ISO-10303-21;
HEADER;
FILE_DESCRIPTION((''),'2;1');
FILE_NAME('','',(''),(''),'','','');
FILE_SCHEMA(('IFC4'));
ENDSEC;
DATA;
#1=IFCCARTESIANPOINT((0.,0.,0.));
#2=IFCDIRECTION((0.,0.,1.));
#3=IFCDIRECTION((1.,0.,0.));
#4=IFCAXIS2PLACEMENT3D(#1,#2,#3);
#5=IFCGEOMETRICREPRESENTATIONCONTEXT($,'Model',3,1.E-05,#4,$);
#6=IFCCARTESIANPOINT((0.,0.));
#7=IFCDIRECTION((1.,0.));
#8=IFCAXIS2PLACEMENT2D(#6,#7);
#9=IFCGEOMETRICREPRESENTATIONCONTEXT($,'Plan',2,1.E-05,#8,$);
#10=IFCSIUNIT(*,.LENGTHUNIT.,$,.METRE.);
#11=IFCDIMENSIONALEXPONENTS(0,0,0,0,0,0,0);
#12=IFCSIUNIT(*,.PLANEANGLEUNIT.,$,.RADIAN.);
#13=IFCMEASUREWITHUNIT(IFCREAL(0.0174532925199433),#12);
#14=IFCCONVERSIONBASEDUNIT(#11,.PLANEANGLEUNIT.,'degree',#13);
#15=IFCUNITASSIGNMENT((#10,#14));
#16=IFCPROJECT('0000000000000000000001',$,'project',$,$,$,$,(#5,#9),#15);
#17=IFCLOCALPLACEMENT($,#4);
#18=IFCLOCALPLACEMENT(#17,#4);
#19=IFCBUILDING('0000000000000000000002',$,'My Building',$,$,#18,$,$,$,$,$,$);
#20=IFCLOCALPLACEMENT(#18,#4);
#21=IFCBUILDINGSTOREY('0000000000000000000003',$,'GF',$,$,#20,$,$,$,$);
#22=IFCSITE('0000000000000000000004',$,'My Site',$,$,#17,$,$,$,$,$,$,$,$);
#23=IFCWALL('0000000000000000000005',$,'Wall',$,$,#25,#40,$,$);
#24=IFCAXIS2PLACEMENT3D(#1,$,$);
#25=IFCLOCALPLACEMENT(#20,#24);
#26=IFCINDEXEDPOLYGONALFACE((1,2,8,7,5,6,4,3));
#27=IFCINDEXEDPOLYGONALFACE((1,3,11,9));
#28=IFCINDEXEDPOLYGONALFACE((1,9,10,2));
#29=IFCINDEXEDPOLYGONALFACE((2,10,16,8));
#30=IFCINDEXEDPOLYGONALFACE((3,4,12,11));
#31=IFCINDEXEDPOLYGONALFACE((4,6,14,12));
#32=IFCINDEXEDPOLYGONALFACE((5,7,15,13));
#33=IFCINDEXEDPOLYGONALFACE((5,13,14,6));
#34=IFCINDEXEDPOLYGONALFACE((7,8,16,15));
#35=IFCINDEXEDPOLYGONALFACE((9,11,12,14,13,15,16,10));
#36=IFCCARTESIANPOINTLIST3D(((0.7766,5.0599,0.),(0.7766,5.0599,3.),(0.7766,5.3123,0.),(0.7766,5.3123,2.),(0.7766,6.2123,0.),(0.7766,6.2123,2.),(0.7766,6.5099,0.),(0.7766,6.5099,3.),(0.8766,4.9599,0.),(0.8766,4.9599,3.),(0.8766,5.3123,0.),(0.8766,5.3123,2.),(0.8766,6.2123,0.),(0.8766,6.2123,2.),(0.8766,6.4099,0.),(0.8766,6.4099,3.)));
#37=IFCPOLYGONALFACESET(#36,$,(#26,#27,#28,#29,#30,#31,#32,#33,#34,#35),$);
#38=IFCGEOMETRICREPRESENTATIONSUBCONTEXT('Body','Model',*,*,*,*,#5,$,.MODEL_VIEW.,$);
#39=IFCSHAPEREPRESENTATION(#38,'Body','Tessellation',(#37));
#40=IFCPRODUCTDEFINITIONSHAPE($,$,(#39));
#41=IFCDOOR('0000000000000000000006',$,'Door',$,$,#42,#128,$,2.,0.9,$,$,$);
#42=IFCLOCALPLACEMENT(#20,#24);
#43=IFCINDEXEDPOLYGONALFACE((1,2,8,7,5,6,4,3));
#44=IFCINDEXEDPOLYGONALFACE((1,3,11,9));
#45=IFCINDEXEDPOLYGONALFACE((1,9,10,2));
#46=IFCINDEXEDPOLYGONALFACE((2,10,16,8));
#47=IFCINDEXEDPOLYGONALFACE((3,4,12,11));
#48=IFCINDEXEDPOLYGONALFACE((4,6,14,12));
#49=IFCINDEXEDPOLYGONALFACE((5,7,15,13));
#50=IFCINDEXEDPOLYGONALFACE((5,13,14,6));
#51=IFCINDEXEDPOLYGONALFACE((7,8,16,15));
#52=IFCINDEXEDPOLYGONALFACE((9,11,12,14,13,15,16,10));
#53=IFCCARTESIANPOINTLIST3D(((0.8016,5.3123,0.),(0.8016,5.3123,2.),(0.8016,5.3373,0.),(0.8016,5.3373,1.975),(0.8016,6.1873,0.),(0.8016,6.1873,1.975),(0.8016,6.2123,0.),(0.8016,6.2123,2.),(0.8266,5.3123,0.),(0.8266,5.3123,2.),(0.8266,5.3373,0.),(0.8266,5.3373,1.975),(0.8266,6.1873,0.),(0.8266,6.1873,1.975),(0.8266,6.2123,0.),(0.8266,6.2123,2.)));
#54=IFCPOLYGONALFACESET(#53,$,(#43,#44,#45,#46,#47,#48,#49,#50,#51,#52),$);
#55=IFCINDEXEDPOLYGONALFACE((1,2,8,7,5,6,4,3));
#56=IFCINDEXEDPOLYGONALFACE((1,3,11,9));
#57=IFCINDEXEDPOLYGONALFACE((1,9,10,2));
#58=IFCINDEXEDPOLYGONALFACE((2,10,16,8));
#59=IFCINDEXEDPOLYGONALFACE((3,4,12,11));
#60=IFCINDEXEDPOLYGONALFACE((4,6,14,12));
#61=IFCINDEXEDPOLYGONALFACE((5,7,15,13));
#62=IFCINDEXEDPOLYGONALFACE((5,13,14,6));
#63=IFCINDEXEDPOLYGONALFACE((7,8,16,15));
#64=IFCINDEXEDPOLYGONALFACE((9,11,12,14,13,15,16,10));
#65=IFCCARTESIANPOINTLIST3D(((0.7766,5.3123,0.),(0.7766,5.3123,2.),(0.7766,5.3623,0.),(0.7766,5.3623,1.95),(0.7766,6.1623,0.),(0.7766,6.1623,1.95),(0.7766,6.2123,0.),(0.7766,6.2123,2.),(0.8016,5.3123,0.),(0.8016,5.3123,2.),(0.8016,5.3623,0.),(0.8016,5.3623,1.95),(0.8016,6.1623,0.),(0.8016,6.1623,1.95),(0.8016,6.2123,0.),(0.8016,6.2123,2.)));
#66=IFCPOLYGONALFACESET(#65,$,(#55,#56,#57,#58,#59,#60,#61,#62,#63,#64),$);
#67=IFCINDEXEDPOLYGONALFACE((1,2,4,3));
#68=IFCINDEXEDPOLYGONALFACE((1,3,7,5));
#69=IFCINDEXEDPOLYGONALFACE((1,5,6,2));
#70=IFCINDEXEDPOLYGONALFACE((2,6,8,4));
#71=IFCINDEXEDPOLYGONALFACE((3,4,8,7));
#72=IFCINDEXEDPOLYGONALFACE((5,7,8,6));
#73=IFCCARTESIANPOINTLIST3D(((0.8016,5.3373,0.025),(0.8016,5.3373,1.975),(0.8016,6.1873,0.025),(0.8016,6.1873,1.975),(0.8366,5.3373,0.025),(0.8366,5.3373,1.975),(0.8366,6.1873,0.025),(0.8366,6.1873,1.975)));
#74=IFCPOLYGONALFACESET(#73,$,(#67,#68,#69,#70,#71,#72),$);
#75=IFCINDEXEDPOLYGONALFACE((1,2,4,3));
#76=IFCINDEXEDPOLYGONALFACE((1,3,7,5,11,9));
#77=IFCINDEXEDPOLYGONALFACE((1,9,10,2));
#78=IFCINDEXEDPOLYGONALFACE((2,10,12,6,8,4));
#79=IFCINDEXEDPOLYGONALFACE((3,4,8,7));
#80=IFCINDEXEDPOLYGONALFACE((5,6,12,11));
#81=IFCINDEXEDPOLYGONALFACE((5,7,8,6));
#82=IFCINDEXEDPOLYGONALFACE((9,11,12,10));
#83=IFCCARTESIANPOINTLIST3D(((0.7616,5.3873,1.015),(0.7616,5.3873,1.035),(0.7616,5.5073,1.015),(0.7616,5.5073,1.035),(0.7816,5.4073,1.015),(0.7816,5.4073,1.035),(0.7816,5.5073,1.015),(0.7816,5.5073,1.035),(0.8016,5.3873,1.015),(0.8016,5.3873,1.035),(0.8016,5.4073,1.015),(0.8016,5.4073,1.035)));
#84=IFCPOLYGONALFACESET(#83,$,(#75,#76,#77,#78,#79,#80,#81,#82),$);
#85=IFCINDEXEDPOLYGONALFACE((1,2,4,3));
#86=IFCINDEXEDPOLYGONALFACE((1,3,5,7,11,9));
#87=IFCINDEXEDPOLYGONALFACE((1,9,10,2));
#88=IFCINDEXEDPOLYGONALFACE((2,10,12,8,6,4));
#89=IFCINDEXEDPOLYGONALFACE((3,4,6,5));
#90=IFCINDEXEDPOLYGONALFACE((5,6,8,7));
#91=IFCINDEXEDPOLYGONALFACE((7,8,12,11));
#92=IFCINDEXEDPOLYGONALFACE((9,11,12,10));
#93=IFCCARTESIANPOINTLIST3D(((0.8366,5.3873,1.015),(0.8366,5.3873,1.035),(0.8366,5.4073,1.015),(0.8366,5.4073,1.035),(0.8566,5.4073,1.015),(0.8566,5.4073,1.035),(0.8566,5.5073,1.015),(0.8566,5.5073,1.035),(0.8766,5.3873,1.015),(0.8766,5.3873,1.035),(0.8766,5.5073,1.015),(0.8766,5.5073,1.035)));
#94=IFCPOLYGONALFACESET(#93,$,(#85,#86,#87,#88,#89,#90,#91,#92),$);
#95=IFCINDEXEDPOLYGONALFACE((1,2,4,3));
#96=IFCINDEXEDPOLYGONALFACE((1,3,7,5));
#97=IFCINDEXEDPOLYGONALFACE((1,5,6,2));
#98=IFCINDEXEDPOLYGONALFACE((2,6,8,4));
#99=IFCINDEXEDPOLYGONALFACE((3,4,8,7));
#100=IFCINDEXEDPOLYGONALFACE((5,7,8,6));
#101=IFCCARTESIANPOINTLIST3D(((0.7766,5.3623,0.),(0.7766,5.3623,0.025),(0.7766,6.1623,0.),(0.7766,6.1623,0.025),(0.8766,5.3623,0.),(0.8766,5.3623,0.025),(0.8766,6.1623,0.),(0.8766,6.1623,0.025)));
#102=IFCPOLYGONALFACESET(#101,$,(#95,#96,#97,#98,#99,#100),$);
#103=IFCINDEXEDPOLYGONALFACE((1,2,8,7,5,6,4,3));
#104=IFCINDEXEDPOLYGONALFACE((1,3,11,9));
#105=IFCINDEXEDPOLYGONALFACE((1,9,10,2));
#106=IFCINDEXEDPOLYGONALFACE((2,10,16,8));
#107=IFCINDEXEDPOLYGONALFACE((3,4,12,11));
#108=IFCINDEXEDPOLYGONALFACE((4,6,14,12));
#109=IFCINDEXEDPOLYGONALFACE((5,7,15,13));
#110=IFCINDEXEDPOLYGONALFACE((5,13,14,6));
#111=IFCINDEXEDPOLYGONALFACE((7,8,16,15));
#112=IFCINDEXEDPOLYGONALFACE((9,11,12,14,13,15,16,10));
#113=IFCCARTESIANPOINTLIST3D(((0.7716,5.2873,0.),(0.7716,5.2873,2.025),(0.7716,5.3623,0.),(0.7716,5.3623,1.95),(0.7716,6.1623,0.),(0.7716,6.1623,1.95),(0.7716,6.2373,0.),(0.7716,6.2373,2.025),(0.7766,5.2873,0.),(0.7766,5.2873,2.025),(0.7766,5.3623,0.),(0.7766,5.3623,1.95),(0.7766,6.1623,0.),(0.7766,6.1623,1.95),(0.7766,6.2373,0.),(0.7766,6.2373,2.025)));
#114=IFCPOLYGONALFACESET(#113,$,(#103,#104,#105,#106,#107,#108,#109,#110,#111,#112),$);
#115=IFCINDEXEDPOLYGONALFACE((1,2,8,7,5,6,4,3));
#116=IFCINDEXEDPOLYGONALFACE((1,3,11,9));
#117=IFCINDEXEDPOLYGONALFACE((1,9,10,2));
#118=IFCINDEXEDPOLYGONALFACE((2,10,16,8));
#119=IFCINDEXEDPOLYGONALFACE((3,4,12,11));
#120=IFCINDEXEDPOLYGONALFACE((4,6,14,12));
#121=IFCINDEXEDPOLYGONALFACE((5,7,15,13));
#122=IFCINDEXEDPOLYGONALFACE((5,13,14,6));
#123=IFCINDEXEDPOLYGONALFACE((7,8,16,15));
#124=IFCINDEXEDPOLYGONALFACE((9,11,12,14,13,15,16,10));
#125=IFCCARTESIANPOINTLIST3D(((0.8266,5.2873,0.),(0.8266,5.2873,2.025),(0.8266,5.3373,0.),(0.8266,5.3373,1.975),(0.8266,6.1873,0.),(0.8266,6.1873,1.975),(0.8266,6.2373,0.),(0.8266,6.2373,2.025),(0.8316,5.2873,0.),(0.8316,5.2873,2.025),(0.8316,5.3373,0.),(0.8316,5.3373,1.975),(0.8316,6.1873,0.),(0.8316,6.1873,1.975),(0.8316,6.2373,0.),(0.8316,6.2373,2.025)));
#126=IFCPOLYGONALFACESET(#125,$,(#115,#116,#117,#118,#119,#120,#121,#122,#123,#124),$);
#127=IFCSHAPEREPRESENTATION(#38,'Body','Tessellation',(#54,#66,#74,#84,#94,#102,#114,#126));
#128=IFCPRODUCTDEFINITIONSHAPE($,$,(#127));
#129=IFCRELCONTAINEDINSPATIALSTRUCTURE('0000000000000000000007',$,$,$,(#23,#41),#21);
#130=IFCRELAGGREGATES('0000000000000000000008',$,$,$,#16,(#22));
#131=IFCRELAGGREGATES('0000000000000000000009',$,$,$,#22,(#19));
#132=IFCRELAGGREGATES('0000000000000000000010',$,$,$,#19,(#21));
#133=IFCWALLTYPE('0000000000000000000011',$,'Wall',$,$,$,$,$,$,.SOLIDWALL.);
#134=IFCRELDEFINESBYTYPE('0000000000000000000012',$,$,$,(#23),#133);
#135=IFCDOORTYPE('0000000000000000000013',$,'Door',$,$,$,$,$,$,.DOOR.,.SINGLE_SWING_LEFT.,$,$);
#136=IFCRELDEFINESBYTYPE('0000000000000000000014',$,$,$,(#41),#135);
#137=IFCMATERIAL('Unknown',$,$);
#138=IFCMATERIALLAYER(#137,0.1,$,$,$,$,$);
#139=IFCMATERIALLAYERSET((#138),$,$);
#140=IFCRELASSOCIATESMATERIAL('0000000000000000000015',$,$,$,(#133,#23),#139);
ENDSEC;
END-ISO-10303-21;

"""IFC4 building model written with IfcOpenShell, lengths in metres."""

from ifc_helpers import new_model, entity, si_unit, converted_unit, frame, origin_with_axes, origin_2d_with_axis, place, context, subcontext, project, spatial, line, indexed_curve, outline, extrude, shape, source, transform, mapped, material, layer, layer_set, layer_usage, type_object, type_shapes, element, fill, save


model = new_model("IFC4")

# Units and contexts
model_context = context("Model", 3, precision=1e-05, world=origin_with_axes())
plan_context = context("Plan", 2, precision=1e-05, world=origin_2d_with_axis())
body_context_1 = subcontext(model_context, "Body", "Model", "MODEL_VIEW")
body_context_2 = subcontext(plan_context, "Body", "Plan", "PLAN_VIEW")
ifc_project = project(units=[si_unit("LENGTHUNIT", "METRE"), converted_unit("PLANEANGLEUNIT", "degree", entity("IfcReal", 0.0174532925199433), si_unit("PLANEANGLEUNIT", "RADIAN"), dimensions=[0, 0, 0, 0, 0, 0, 0])], contexts=[model_context, plan_context])

# Site, building, storey
site_placement = place(None, origin_with_axes())
site = spatial("IfcSite", under=ifc_project, at=site_placement, Name="My Site")
building_placement = place(site_placement, origin_with_axes())
building = spatial("IfcBuilding", under=site, at=building_placement, Name="My Building")
storey_placement = place(building_placement, origin_with_axes())
storey = spatial("IfcBuildingStorey", under=building, at=storey_placement, Name="GF")

# Shared definitions
ifc_material_1 = material(Name="Unknown")

# Shared definitions
ifc_layer_1 = layer(ifc_material_1, 0.1)
ifc_layer_set_1 = layer_set([ifc_layer_1])
wall_type = type_object("IfcWallType", Name="Wall", PredefinedType="SOLIDWALL", material=ifc_layer_set_1)

# Wall, opening, door
ifc_layer_usage_1 = layer_usage(ifc_layer_set_1, "AXIS2", "POSITIVE", 0.0)
wall_1_placement = place(storey_placement, frame((0.7766, 6.5099, 0.0), z_axis=(0.0, 0.0, 1.0), x_axis=(0.0, -1.0, 0.0)))
wall_1 = element("IfcWall", 1, at=wall_1_placement, inside=storey, type_object=wall_type, material=ifc_layer_usage_1, Name="Wall", context=body_context_1, shape_type="SweptSolid", body=[
    extrude(outline(indexed_curve([(0.0, 0.0), (0.1, 0.1), (1.55, 0.1), (1.45, 0.0)], segments=[line(1, 2, 3, 4, 1)])), origin_with_axes(), (0.0, 0.0, 1.0), 3.0),
])
shared_shape_1 = source(origin_with_axes(), body_context_1, "Body", "SweptSolid", [
    extrude(outline(indexed_curve([(0.0, 0.0), (0.9, 0.0), (0.9, 2.0), (0.0, 2.0)], segments=[line(1, 2, 3, 4, 1)])), frame((0.0, -0.6, 0.0), z_axis=(0.0, -1.0, 0.0), x_axis=(1.0, 0.0, 0.0)), (0.0, 0.0, -1.0), 1.2),
])
opening_1_placement = place(wall_1_placement, frame((0.2976, 0.0, 0.0), z_axis=(0.0, 0.0, 1.0), x_axis=(1.0, 0.0, 0.0)))
opening_1 = element("IfcOpeningElement", 2, at=opening_1_placement, cuts=wall_1, PredefinedType="OPENING", context=body_context_1, shape_type="MappedRepresentation", body=[
    mapped(shared_shape_1, transform((0.0, 0.0, 0.0), x_axis=(1.0, 0.0, 0.0), y_axis=(0.0, 1.0, 0.0), z_axis=(0.0, 0.0, 1.0), scale=1.0)),
])
door_type = type_object("IfcDoorType", Name="Door", OperationType="SINGLE_SWING_LEFT", PredefinedType="DOOR")
shared_shape_2 = source(origin_with_axes(), body_context_1, "Body", "SweptSolid", [
    extrude(outline(indexed_curve([(0.0, 0.0), (0.0, 2.0), (0.9, 2.0), (0.9, 0.0), (0.875, 0.0), (0.875, 1.975), (0.025, 1.975), (0.025, 0.0)], segments=[line(1, 2, 3, 4, 5, 6, 7, 8, 1)])), frame((0.0, 0.025, 0.0), z_axis=(0.0, -1.0, 0.0), x_axis=(1.0, 0.0, 0.0)), (0.0, 0.0, -1.0), 0.025),
    extrude(outline(indexed_curve([(0.0, 0.0), (0.0, 2.0), (0.9, 2.0), (0.9, 0.0), (0.85, 0.0), (0.85, 1.95), (0.05, 1.95), (0.05, 0.0)], segments=[line(1, 2, 3, 4, 5, 6, 7, 8, 1)])), frame((0.0, 0.0, 0.0), z_axis=(0.0, -1.0, 0.0), x_axis=(1.0, 0.0, 0.0)), (0.0, 0.0, -1.0), 0.025),
    extrude(outline(indexed_curve([(0.0, 0.0), (0.85, 0.0), (0.85, 0.035), (0.0, 0.035)], segments=[line(1, 2, 3, 4, 1)])), frame((0.025, 0.025, 0.025), z_axis=(0.0, 0.0, 1.0), x_axis=(1.0, 0.0, 0.0)), (0.0, 0.0, 1.0), 1.95),
    extrude(outline(indexed_curve([(0.0, 0.0), (0.0, -0.04), (-0.12, -0.04), (-0.12, -0.02), (-0.02, -0.02), (-0.02, 0.0)], segments=[line(1, 2, 3, 4, 5, 6, 1)])), frame((0.825, 0.025, 1.015), z_axis=(0.0, 0.0, 1.0), x_axis=(1.0, 0.0, 0.0)), (0.0, 0.0, 1.0), 0.02),
    extrude(outline(indexed_curve([(0.0, 0.0), (0.0, 0.04), (-0.12, 0.04), (-0.12, 0.02), (-0.02, 0.02), (-0.02, 0.0)], segments=[line(1, 2, 3, 4, 5, 6, 1)])), frame((0.825, 0.06, 1.015), z_axis=(0.0, 0.0, 1.0), x_axis=(1.0, 0.0, 0.0)), (0.0, 0.0, 1.0), 0.02),
    extrude(outline(indexed_curve([(0.0, 0.0), (0.8, 0.0), (0.8, 0.1), (0.0, 0.1)], segments=[line(1, 2, 3, 4, 1)])), frame((0.05, 0.0, 0.0), z_axis=(0.0, 0.0, 1.0), x_axis=(1.0, 0.0, 0.0)), (0.0, 0.0, 1.0), 0.025),
    extrude(outline(indexed_curve([(0.0, 0.0), (0.0, 2.025), (0.95, 2.025), (0.95, 0.0), (0.875, 0.0), (0.875, 1.95), (0.075, 1.95), (0.075, 0.0)], segments=[line(1, 2, 3, 4, 5, 6, 7, 8, 1)])), frame((-0.025, -0.005, 0.0), z_axis=(0.0, -1.0, 0.0), x_axis=(1.0, 0.0, 0.0)), (0.0, 0.0, -1.0), 0.005),
    extrude(outline(indexed_curve([(0.0, 0.0), (0.0, 2.025), (0.95, 2.025), (0.95, 0.0), (0.9, 0.0), (0.9, 1.975), (0.05, 1.975), (0.05, 0.0)], segments=[line(1, 2, 3, 4, 5, 6, 7, 8, 1)])), frame((-0.025, 0.05, 0.0), z_axis=(0.0, -1.0, 0.0), x_axis=(1.0, 0.0, 0.0)), (0.0, 0.0, -1.0), 0.005),
])
shared_shape_3 = source(origin_with_axes(), body_context_2, "Body", "Curve2D", [
    entity("IfcIndexedPolyCurve", entity("IfcCartesianPointList2D", [[0.0, 0.0], [0.0, 0.05], [0.025, 0.05], [0.025, 0.025], [0.05, 0.025], [0.05, 0.0]]), [entity("IfcLineIndex", [1, 2, 3, 4, 5, 6, 1])]),
    entity("IfcIndexedPolyCurve", entity("IfcCartesianPointList2D", [[0.9, 0.0], [0.9, 0.05], [0.875, 0.05], [0.875, 0.025], [0.85, 0.025], [0.85, 0.0]]), [entity("IfcLineIndex", [1, 2, 3, 4, 5, 6, 1])]),
    entity("IfcTrimmedCurve", entity("IfcEllipse", entity("IfcAxis2Placement2D", entity("IfcCartesianPoint", [0.06, 0.05]), entity("IfcDirection", [1.0, 0.0])), 0.815, 0.85), [entity("IfcCartesianPoint", [0.875, 0.05])], [entity("IfcCartesianPoint", [0.06, 0.9])], True, "CARTESIAN"),
    entity("IfcIndexedPolyCurve", entity("IfcCartesianPointList2D", [[0.025, 0.05], [0.06, 0.05], [0.06, 0.9], [0.025, 0.9]]), [entity("IfcLineIndex", [1, 2, 3, 4, 1])]),
])
type_shapes(door_type, [shared_shape_2, shared_shape_3])
door_1_placement = place(opening_1_placement, frame((0.0, 0.0, 0.0), z_axis=(0.0, 0.0, 1.0), x_axis=(1.0, 0.0, 0.0)))
door_1 = element("IfcDoor", 3, at=door_1_placement, inside=storey, type_object=door_type, Name="Door", OverallHeight=2.0, OverallWidth=0.9, shapes=[
    shape(body_context_1, "Body", "MappedRepresentation", [mapped(shared_shape_2, transform((0.0, 0.0, 0.0), x_axis=(1.0, 0.0, 0.0), y_axis=(0.0, 1.0, 0.0), z_axis=(0.0, 0.0, 1.0), scale=1.0))]),
    shape(body_context_2, "Body", "MappedRepresentation", [mapped(shared_shape_3, transform((0.0, 0.0, 0.0), x_axis=(1.0, 0.0, 0.0), y_axis=(0.0, 1.0, 0.0), z_axis=(0.0, 0.0, 1.0), scale=1.0))]),
])
fill(opening_1, door_1)

save(model, "model.ifc")
